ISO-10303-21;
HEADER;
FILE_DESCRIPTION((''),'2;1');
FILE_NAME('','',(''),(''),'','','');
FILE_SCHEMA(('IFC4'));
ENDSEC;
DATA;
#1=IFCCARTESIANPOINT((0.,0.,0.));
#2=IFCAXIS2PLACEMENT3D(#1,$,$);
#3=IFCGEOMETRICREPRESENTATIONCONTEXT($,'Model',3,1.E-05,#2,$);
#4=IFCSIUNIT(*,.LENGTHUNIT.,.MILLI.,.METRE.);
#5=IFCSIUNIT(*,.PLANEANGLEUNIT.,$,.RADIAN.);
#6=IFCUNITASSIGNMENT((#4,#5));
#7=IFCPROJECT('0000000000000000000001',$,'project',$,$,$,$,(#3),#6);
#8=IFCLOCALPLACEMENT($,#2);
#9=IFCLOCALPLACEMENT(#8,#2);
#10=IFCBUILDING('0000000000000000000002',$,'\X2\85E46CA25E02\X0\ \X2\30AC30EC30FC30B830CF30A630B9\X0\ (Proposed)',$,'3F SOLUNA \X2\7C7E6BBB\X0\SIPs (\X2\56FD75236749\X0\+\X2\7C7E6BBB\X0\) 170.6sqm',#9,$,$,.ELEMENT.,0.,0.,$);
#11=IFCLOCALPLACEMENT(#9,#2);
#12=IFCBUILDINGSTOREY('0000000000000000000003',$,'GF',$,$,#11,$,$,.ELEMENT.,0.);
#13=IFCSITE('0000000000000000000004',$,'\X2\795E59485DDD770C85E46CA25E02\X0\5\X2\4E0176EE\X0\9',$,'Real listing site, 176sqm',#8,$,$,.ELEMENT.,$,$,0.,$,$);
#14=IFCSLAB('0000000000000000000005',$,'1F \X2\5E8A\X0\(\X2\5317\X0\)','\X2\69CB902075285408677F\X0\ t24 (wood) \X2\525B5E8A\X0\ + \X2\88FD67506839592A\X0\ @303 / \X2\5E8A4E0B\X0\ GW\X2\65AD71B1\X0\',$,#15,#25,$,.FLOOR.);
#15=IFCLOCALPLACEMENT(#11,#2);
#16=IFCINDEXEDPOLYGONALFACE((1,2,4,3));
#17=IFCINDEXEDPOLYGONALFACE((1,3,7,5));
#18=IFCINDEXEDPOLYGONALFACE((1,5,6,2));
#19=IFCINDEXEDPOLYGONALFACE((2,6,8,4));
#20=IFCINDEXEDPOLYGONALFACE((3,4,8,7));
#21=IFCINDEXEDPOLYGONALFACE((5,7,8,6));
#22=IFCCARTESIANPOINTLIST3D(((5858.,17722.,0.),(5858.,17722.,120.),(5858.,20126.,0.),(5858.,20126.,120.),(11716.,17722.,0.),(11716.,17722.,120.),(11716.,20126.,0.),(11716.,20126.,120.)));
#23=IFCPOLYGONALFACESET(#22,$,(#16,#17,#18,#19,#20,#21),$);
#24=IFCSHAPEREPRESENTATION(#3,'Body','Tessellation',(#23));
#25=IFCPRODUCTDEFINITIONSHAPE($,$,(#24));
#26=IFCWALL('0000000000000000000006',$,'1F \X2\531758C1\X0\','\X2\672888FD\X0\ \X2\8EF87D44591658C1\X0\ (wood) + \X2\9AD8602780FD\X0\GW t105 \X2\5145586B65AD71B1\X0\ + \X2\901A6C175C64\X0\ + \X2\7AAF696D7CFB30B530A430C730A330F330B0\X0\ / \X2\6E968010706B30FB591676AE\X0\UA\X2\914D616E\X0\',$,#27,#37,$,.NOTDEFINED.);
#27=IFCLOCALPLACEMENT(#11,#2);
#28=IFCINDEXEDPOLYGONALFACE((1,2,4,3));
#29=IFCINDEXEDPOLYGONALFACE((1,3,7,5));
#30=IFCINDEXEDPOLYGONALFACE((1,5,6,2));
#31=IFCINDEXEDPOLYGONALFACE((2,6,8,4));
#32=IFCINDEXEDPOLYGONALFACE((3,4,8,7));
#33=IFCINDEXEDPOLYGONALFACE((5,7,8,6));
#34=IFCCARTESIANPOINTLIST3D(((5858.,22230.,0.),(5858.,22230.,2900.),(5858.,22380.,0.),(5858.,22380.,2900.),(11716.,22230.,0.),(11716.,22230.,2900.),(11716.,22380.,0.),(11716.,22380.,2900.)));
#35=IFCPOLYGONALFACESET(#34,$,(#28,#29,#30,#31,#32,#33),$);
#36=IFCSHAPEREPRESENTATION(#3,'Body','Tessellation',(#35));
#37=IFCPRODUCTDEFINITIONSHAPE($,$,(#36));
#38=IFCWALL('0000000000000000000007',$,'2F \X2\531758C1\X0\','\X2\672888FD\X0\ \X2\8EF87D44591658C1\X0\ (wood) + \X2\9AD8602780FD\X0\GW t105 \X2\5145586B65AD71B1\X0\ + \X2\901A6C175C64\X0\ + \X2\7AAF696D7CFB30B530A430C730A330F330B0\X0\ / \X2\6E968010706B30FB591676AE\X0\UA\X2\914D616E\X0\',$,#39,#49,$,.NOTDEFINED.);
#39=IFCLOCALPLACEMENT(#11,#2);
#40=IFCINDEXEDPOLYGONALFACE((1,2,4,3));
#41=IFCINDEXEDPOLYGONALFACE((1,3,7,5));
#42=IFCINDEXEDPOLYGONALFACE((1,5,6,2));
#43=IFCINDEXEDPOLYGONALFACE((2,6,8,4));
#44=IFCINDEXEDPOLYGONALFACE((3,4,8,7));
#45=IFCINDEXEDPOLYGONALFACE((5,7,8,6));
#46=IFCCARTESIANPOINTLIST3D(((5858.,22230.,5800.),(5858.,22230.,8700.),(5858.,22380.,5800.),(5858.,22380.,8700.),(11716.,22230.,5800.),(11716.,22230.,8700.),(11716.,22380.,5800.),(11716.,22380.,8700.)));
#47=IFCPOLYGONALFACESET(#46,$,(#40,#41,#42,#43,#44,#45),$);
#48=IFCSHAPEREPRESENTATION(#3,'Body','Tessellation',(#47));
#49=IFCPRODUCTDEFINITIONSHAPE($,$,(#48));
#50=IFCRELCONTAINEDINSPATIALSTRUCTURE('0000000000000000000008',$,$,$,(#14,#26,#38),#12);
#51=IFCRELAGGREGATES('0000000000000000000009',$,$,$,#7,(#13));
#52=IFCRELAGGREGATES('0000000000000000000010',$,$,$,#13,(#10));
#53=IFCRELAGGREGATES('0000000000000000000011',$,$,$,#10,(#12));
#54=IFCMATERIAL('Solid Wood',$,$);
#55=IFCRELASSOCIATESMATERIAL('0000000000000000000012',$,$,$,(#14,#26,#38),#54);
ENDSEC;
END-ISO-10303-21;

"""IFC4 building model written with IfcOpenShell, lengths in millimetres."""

from ifc_helpers import new_model, si_unit, frame, frame_2d, origin, place, context, project, spatial, rectangle, extrude, material, element, save


model = new_model("IFC4")

# Units and contexts
model_context = context("Model", 3, precision=1e-05, world=origin())
ifc_project = project(units=[si_unit("LENGTHUNIT", "METRE", prefix="MILLI"), si_unit("PLANEANGLEUNIT", "RADIAN")], contexts=[model_context])

# Site, building, storey
site_placement = place(None, origin())
site = spatial("IfcSite", under=ifc_project, at=site_placement, Name="神奈川県藤沢市5丁目9", ObjectType="Real listing site, 176sqm", CompositionType="ELEMENT", RefElevation=0.0)
building_placement = place(site_placement, origin())
building = spatial("IfcBuilding", under=site, at=building_placement, Name="藤沢市 ガレージハウス (Proposed)", ObjectType="3F SOLUNA 籾殻SIPs (国産杉+籾殻) 170.6sqm", CompositionType="ELEMENT", ElevationOfRefHeight=0.0, ElevationOfTerrain=0.0)
storey_placement = place(building_placement, origin())
storey = spatial("IfcBuildingStorey", under=building, at=storey_placement, Name="GF", CompositionType="ELEMENT", Elevation=0.0)

# Slab
ifc_material_1 = material(Name="Solid Wood")
slab_1_placement = place(storey_placement, frame((2929.0, 8861.0, 0.0)))
element("IfcSlab", 1, at=slab_1_placement, inside=storey, material=ifc_material_1, Name="1F 床(北)", Description="構造用合板 t24 (wood) 剛床 + 製材根太 @303 / 床下 GW断熱", PredefinedType="FLOOR", context=model_context, shape_type="SweptSolid", body=[
    extrude(rectangle(XDim=5858.0, YDim=2404.0, at=frame_2d((2929.0, 1202.0))), frame((2929.0, 8861.0, 0.0)), (0.0, 0.0, 1.0), 120.0),
])

# Wall
wall_1_placement = place(storey_placement, frame((2929.0, 11115.0, 0.0)))
element("IfcWall", 2, at=wall_1_placement, inside=storey, material=ifc_material_1, Name="1F 北壁", Description="木製 軸組外壁 (wood) + 高性能GW t105 充填断熱 + 通気層 + 窯業系サイディング / 準耐火・外皮UA配慮", PredefinedType="NOTDEFINED", context=model_context, shape_type="SweptSolid", body=[
    extrude(rectangle(XDim=5858.0, YDim=150.0, at=frame_2d((2929.0, 75.0))), frame((2929.0, 11115.0, 0.0)), (0.0, 0.0, 1.0), 2900.0),
])

# Wall
wall_2_placement = place(storey_placement, frame((2929.0, 11115.0, 2900.0)))
element("IfcWall", 3, at=wall_2_placement, inside=storey, material=ifc_material_1, Name="2F 北壁", Description="木製 軸組外壁 (wood) + 高性能GW t105 充填断熱 + 通気層 + 窯業系サイディング / 準耐火・外皮UA配慮", PredefinedType="NOTDEFINED", context=model_context, shape_type="SweptSolid", body=[
    extrude(rectangle(XDim=5858.0, YDim=150.0, at=frame_2d((2929.0, 75.0))), frame((2929.0, 11115.0, 2900.0)), (0.0, 0.0, 1.0), 2900.0),
])

save(model, "model.ifc")
